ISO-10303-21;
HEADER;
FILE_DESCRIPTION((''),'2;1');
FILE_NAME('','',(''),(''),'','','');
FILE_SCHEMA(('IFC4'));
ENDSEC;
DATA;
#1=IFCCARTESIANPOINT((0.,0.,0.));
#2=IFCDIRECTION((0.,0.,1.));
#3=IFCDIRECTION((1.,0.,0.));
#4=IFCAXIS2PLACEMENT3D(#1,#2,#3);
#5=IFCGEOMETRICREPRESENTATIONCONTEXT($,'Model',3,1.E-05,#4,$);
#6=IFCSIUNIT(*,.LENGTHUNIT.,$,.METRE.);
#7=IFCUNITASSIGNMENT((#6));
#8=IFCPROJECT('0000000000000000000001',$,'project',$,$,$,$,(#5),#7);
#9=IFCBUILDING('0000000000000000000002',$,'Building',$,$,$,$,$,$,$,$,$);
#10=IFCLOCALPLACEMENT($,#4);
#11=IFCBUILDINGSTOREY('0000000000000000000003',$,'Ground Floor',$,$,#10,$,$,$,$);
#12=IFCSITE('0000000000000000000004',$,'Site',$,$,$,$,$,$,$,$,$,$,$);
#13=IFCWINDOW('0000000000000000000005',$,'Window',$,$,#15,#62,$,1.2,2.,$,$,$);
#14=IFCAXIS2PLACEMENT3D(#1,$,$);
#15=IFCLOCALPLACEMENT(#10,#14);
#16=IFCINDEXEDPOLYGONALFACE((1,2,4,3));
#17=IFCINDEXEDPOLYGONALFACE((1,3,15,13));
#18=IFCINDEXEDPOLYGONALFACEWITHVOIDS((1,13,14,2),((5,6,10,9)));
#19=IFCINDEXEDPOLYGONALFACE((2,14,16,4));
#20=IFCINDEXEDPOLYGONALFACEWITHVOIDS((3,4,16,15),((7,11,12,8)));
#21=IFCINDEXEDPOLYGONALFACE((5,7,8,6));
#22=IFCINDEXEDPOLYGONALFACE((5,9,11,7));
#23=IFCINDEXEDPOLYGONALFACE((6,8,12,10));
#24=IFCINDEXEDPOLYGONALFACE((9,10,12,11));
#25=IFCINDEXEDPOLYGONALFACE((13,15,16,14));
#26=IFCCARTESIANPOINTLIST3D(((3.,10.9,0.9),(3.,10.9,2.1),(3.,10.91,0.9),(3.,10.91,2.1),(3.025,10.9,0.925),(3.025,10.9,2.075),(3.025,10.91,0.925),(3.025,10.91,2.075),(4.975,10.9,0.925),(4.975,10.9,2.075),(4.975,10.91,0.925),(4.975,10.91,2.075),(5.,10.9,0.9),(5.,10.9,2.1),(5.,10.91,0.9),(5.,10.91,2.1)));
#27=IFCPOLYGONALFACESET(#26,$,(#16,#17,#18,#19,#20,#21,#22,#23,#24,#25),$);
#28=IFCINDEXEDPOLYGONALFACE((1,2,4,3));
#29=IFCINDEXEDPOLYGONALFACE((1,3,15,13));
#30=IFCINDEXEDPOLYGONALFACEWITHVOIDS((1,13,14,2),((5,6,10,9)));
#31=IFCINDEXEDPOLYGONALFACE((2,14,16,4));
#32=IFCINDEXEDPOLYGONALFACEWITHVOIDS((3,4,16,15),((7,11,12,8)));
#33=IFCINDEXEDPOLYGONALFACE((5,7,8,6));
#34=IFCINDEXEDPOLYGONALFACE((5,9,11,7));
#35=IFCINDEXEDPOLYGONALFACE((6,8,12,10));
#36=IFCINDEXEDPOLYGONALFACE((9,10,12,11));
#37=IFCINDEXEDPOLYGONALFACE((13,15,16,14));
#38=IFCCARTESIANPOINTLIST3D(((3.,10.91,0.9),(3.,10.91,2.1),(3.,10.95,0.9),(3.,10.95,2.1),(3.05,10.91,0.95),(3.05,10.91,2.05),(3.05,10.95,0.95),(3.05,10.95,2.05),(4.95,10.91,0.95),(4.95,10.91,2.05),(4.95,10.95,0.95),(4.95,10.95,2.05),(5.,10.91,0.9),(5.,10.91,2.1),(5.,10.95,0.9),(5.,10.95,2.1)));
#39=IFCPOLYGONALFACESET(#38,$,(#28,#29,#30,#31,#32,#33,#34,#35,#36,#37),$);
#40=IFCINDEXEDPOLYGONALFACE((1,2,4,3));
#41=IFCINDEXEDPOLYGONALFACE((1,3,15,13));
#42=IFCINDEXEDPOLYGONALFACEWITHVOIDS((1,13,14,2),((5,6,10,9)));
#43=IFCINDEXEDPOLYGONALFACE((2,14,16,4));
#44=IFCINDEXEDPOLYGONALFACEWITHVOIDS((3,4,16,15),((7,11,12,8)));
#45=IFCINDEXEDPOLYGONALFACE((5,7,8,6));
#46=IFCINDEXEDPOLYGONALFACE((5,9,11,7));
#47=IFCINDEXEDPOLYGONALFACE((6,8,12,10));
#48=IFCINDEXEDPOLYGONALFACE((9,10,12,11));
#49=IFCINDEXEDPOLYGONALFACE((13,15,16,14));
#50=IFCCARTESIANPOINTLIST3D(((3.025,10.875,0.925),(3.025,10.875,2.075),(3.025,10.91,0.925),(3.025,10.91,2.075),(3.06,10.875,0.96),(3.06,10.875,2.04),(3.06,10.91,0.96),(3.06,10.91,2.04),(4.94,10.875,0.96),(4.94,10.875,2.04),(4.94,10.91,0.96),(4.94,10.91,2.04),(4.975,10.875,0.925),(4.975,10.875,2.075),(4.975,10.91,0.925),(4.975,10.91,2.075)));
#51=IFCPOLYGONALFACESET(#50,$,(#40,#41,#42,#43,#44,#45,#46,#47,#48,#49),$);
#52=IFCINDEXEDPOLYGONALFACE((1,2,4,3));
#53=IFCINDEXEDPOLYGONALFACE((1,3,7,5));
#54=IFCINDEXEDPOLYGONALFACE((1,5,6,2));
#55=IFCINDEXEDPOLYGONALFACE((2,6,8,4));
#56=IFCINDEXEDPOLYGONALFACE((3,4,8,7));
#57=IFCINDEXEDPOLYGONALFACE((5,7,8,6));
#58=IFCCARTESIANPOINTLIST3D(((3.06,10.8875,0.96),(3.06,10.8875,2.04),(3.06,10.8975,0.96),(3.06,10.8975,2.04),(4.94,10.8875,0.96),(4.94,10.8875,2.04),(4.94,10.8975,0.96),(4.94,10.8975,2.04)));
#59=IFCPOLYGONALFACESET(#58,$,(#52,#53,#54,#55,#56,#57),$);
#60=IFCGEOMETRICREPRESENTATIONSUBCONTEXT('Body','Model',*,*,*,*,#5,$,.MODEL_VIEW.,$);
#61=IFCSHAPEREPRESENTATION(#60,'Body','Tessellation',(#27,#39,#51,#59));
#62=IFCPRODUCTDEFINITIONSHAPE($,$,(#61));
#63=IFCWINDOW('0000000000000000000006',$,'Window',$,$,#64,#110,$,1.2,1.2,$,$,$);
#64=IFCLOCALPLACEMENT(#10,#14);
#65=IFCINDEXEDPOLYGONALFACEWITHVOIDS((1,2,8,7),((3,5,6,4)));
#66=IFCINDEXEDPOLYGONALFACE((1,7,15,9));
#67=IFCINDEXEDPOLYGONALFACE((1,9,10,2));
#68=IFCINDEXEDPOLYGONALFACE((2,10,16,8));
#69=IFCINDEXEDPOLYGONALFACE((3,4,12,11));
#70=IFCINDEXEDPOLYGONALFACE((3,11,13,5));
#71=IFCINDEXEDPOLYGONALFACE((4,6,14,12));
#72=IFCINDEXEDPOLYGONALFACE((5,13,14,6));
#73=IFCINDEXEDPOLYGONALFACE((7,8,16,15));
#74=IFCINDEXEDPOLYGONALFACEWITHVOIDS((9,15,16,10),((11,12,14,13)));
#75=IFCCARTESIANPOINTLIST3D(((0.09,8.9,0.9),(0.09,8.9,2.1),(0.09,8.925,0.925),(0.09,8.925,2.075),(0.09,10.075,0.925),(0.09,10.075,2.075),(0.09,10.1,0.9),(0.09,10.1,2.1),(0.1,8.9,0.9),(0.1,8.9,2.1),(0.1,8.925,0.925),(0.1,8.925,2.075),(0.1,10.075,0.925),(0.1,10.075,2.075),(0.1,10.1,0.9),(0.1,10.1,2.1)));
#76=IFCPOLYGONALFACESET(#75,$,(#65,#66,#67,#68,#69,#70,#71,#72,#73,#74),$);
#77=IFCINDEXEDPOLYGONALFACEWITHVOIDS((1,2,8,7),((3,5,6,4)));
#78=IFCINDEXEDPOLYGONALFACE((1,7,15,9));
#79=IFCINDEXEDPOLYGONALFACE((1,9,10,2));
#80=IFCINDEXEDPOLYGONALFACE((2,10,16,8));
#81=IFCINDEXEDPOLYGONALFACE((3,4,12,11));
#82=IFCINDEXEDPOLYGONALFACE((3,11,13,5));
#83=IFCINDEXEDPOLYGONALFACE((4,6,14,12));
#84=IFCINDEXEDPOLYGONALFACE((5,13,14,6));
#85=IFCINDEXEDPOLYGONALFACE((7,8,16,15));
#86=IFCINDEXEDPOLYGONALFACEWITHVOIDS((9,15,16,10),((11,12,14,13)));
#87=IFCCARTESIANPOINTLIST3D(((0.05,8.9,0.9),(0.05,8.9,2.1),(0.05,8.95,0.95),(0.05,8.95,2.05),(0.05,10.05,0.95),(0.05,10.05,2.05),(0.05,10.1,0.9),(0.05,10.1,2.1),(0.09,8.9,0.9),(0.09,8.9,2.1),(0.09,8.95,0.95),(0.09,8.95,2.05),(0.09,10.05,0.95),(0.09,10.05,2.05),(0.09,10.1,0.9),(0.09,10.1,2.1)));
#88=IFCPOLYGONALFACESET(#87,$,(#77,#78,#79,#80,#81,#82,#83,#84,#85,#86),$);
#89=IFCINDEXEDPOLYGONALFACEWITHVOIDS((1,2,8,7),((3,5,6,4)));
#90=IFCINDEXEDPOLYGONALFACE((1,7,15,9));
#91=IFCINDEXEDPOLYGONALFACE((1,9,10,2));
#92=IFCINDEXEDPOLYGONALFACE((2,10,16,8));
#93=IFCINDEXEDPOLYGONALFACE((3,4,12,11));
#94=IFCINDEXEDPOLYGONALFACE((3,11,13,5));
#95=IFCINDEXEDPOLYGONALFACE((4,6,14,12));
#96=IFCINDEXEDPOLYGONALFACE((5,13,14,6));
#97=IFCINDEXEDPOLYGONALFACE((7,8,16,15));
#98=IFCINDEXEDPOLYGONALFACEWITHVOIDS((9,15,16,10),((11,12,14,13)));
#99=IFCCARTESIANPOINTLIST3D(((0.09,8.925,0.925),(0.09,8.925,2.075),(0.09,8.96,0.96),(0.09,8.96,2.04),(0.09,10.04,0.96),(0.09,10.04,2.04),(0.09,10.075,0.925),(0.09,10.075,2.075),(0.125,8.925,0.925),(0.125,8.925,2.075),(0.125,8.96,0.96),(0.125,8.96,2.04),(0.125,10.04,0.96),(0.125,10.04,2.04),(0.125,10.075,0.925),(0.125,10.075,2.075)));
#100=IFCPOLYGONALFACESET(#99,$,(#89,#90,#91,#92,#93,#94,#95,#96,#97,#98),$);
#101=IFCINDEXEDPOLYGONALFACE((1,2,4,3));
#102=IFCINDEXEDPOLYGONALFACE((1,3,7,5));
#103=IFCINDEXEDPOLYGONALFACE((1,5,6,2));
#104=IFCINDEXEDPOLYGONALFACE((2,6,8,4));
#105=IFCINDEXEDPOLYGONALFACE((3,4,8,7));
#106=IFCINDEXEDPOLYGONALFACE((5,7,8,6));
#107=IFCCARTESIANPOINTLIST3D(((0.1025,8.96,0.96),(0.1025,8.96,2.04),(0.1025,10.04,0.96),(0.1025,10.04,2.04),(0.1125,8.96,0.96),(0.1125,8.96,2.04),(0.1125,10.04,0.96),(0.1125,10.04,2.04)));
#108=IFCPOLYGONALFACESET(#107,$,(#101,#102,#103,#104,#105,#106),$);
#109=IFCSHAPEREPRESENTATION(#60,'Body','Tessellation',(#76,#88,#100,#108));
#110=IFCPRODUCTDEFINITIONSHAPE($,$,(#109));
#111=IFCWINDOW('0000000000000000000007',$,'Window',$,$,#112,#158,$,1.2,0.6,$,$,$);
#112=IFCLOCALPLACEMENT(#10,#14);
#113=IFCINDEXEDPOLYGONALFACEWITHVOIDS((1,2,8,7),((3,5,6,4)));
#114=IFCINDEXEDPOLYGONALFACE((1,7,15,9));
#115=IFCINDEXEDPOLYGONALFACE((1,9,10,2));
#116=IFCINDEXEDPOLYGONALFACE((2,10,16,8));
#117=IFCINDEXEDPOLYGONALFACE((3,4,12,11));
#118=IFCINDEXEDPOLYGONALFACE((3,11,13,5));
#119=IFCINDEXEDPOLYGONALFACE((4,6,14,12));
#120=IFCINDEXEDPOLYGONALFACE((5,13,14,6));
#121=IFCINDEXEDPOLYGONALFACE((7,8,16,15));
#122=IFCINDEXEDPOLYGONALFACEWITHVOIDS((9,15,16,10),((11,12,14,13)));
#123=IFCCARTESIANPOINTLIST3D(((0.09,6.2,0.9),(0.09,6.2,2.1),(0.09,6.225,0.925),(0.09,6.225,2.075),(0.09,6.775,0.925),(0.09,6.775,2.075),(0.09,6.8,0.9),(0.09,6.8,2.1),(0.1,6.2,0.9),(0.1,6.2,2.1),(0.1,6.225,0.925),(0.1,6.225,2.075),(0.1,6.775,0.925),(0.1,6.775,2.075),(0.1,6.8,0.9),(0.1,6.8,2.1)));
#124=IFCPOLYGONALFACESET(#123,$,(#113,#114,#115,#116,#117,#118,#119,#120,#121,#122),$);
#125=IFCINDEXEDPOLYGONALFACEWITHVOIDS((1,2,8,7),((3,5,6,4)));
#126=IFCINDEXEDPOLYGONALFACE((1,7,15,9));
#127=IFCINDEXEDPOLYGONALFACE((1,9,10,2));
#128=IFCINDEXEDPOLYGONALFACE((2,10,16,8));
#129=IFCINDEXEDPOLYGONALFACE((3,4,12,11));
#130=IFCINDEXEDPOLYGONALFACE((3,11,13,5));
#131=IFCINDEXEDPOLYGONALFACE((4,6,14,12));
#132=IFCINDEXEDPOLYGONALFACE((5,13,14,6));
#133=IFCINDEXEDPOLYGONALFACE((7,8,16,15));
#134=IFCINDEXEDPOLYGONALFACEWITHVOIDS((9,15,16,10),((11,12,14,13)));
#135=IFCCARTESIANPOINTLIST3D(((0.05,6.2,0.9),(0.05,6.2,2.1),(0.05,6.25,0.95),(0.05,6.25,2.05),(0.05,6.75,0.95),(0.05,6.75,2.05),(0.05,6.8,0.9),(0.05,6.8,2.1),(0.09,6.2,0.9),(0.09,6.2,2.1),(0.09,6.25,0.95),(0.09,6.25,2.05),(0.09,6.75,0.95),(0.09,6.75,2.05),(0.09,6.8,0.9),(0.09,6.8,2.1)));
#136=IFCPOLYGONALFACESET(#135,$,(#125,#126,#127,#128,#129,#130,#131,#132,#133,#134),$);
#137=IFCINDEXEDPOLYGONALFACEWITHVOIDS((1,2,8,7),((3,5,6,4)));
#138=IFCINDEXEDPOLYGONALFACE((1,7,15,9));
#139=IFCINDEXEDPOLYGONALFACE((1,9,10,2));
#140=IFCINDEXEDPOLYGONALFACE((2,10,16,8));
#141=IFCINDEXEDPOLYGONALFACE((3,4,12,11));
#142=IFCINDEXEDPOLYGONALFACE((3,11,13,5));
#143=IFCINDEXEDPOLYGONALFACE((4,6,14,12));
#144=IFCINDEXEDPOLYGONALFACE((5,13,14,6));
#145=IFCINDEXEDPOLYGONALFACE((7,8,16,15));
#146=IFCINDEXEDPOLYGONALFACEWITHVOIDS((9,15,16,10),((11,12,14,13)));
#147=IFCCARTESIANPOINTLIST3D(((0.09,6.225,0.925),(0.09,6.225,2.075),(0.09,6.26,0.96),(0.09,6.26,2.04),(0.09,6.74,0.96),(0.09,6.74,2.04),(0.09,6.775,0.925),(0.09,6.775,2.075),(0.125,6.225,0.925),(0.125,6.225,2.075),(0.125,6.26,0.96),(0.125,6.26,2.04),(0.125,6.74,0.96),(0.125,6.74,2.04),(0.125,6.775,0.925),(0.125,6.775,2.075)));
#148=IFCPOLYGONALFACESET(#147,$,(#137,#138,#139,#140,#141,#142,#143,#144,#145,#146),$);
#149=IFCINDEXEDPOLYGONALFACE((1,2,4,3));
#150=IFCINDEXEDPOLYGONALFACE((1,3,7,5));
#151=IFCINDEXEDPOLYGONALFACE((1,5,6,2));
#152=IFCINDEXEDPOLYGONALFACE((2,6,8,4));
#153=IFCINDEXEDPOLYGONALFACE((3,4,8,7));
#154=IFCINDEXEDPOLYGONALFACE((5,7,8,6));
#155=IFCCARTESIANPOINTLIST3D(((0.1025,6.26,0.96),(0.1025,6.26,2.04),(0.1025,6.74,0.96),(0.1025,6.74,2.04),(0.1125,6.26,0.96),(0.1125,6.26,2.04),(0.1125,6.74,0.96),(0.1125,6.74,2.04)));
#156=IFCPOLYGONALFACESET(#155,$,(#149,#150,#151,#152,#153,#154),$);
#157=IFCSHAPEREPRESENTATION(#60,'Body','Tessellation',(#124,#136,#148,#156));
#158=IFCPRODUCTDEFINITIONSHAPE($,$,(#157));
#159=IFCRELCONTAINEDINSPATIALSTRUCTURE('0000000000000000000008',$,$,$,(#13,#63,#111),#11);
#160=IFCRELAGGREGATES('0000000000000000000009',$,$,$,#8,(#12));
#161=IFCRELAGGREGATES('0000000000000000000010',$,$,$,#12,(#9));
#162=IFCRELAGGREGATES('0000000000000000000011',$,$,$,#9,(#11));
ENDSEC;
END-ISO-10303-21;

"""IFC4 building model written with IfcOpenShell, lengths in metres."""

from ifc_helpers import new_model, si_unit, frame, origin_with_axes, place, context, subcontext, project, spatial, line, indexed_curve, outline, extrude, element, save


model = new_model("IFC4")

# Units and contexts
model_context = context("Model", 3, precision=1e-05, world=origin_with_axes())
body_context = subcontext(model_context, "Body", "Model", "MODEL_VIEW")
ifc_project = project(units=[si_unit("LENGTHUNIT", "METRE")], contexts=[model_context])

# Site, building, storey
site = spatial("IfcSite", under=ifc_project, Name="Site")
building = spatial("IfcBuilding", under=site, Name="Building")
storey_placement = place(None, origin_with_axes())
storey = spatial("IfcBuildingStorey", under=building, at=storey_placement, Name="Ground Floor")

# Windows
window_1_placement = place(storey_placement, frame((5.0, 11.0, 0.9), z_axis=(0.0, 0.0, 1.0), x_axis=(-1.0, 0.0, 0.0)))
element("IfcWindow", 1, at=window_1_placement, inside=storey, Name="Window", OverallHeight=1.2, OverallWidth=2.0, context=body_context, shape_type="SweptSolid", body=[
    extrude(outline(indexed_curve([(0.0, 0.0), (2.0, 0.0), (2.0, 1.2), (0.0, 1.2)], segments=[line(1, 2, 3, 4, 1)]), holes=[indexed_curve([(0.025, 0.025), (1.975, 0.025), (1.975, 1.175), (0.025, 1.175)], segments=[line(1, 2, 3, 4, 1)])]), frame((0.0, 0.09, 0.0), z_axis=(0.0, -1.0, 0.0), x_axis=(1.0, 0.0, 0.0)), (0.0, 0.0, -1.0), 0.01),
    extrude(outline(indexed_curve([(0.0, 0.0), (2.0, 0.0), (2.0, 1.2), (0.0, 1.2)], segments=[line(1, 2, 3, 4, 1)]), holes=[indexed_curve([(0.05, 0.05), (1.95, 0.05), (1.95, 1.15), (0.05, 1.15)], segments=[line(1, 2, 3, 4, 1)])]), frame((0.0, 0.05, 0.0), z_axis=(0.0, -1.0, 0.0), x_axis=(1.0, 0.0, 0.0)), (0.0, 0.0, -1.0), 0.04),
    extrude(outline(indexed_curve([(0.0, 0.0), (1.95, 0.0), (1.95, 1.15), (0.0, 1.15)], segments=[line(1, 2, 3, 4, 1)]), holes=[indexed_curve([(0.035, 0.035), (1.915, 0.035), (1.915, 1.115), (0.035, 1.115)], segments=[line(1, 2, 3, 4, 1)])]), frame((0.025, 0.09, 0.025), z_axis=(0.0, -1.0, 0.0), x_axis=(1.0, 0.0, 0.0)), (0.0, 0.0, -1.0), 0.035),
    extrude(outline(indexed_curve([(0.035, 0.035), (1.915, 0.035), (1.915, 1.115), (0.035, 1.115)], segments=[line(1, 2, 3, 4, 1)])), frame((0.025, 0.1025, 0.025), z_axis=(0.0, -1.0, 0.0), x_axis=(1.0, 0.0, 0.0)), (0.0, 0.0, -1.0), 0.01),
])
window_2_placement = place(storey_placement, frame((0.0, 10.1, 0.9), z_axis=(0.0, 0.0, 1.0), x_axis=(0.0, -1.0, 0.0)))
element("IfcWindow", 2, at=window_2_placement, inside=storey, Name="Window", OverallHeight=1.2, OverallWidth=1.2, context=body_context, shape_type="SweptSolid", body=[
    extrude(outline(indexed_curve([(0.0, 0.0), (1.2, 0.0), (1.2, 1.2), (0.0, 1.2)], segments=[line(1, 2, 3, 4, 1)]), holes=[indexed_curve([(0.025, 0.025), (1.175, 0.025), (1.175, 1.175), (0.025, 1.175)], segments=[line(1, 2, 3, 4, 1)])]), frame((0.0, 0.09, 0.0), z_axis=(0.0, -1.0, 0.0), x_axis=(1.0, 0.0, 0.0)), (0.0, 0.0, -1.0), 0.01),
    extrude(outline(indexed_curve([(0.0, 0.0), (1.2, 0.0), (1.2, 1.2), (0.0, 1.2)], segments=[line(1, 2, 3, 4, 1)]), holes=[indexed_curve([(0.05, 0.05), (1.15, 0.05), (1.15, 1.15), (0.05, 1.15)], segments=[line(1, 2, 3, 4, 1)])]), frame((0.0, 0.05, 0.0), z_axis=(0.0, -1.0, 0.0), x_axis=(1.0, 0.0, 0.0)), (0.0, 0.0, -1.0), 0.04),
    extrude(outline(indexed_curve([(0.0, 0.0), (1.15, 0.0), (1.15, 1.15), (0.0, 1.15)], segments=[line(1, 2, 3, 4, 1)]), holes=[indexed_curve([(0.035, 0.035), (1.115, 0.035), (1.115, 1.115), (0.035, 1.115)], segments=[line(1, 2, 3, 4, 1)])]), frame((0.025, 0.09, 0.025), z_axis=(0.0, -1.0, 0.0), x_axis=(1.0, 0.0, 0.0)), (0.0, 0.0, -1.0), 0.035),
    extrude(outline(indexed_curve([(0.035, 0.035), (1.115, 0.035), (1.115, 1.115), (0.035, 1.115)], segments=[line(1, 2, 3, 4, 1)])), frame((0.025, 0.1025, 0.025), z_axis=(0.0, -1.0, 0.0), x_axis=(1.0, 0.0, 0.0)), (0.0, 0.0, -1.0), 0.01),
])
window_3_placement = place(storey_placement, frame((0.0, 6.8, 0.9), z_axis=(0.0, 0.0, 1.0), x_axis=(0.0, -1.0, 0.0)))
element("IfcWindow", 3, at=window_3_placement, inside=storey, Name="Window", OverallHeight=1.2, OverallWidth=0.6, context=body_context, shape_type="SweptSolid", body=[
    extrude(outline(indexed_curve([(0.0, 0.0), (0.6, 0.0), (0.6, 1.2), (0.0, 1.2)], segments=[line(1, 2, 3, 4, 1)]), holes=[indexed_curve([(0.025, 0.025), (0.575, 0.025), (0.575, 1.175), (0.025, 1.175)], segments=[line(1, 2, 3, 4, 1)])]), frame((0.0, 0.09, 0.0), z_axis=(0.0, -1.0, 0.0), x_axis=(1.0, 0.0, 0.0)), (0.0, 0.0, -1.0), 0.01),
    extrude(outline(indexed_curve([(0.0, 0.0), (0.6, 0.0), (0.6, 1.2), (0.0, 1.2)], segments=[line(1, 2, 3, 4, 1)]), holes=[indexed_curve([(0.05, 0.05), (0.55, 0.05), (0.55, 1.15), (0.05, 1.15)], segments=[line(1, 2, 3, 4, 1)])]), frame((0.0, 0.05, 0.0), z_axis=(0.0, -1.0, 0.0), x_axis=(1.0, 0.0, 0.0)), (0.0, 0.0, -1.0), 0.04),
    extrude(outline(indexed_curve([(0.0, 0.0), (0.55, 0.0), (0.55, 1.15), (0.0, 1.15)], segments=[line(1, 2, 3, 4, 1)]), holes=[indexed_curve([(0.035, 0.035), (0.515, 0.035), (0.515, 1.115), (0.035, 1.115)], segments=[line(1, 2, 3, 4, 1)])]), frame((0.025, 0.09, 0.025), z_axis=(0.0, -1.0, 0.0), x_axis=(1.0, 0.0, 0.0)), (0.0, 0.0, -1.0), 0.035),
    extrude(outline(indexed_curve([(0.035, 0.035), (0.515, 0.035), (0.515, 1.115), (0.035, 1.115)], segments=[line(1, 2, 3, 4, 1)])), frame((0.025, 0.1025, 0.025), z_axis=(0.0, -1.0, 0.0), x_axis=(1.0, 0.0, 0.0)), (0.0, 0.0, -1.0), 0.01),
])

save(model, "model.ifc")
